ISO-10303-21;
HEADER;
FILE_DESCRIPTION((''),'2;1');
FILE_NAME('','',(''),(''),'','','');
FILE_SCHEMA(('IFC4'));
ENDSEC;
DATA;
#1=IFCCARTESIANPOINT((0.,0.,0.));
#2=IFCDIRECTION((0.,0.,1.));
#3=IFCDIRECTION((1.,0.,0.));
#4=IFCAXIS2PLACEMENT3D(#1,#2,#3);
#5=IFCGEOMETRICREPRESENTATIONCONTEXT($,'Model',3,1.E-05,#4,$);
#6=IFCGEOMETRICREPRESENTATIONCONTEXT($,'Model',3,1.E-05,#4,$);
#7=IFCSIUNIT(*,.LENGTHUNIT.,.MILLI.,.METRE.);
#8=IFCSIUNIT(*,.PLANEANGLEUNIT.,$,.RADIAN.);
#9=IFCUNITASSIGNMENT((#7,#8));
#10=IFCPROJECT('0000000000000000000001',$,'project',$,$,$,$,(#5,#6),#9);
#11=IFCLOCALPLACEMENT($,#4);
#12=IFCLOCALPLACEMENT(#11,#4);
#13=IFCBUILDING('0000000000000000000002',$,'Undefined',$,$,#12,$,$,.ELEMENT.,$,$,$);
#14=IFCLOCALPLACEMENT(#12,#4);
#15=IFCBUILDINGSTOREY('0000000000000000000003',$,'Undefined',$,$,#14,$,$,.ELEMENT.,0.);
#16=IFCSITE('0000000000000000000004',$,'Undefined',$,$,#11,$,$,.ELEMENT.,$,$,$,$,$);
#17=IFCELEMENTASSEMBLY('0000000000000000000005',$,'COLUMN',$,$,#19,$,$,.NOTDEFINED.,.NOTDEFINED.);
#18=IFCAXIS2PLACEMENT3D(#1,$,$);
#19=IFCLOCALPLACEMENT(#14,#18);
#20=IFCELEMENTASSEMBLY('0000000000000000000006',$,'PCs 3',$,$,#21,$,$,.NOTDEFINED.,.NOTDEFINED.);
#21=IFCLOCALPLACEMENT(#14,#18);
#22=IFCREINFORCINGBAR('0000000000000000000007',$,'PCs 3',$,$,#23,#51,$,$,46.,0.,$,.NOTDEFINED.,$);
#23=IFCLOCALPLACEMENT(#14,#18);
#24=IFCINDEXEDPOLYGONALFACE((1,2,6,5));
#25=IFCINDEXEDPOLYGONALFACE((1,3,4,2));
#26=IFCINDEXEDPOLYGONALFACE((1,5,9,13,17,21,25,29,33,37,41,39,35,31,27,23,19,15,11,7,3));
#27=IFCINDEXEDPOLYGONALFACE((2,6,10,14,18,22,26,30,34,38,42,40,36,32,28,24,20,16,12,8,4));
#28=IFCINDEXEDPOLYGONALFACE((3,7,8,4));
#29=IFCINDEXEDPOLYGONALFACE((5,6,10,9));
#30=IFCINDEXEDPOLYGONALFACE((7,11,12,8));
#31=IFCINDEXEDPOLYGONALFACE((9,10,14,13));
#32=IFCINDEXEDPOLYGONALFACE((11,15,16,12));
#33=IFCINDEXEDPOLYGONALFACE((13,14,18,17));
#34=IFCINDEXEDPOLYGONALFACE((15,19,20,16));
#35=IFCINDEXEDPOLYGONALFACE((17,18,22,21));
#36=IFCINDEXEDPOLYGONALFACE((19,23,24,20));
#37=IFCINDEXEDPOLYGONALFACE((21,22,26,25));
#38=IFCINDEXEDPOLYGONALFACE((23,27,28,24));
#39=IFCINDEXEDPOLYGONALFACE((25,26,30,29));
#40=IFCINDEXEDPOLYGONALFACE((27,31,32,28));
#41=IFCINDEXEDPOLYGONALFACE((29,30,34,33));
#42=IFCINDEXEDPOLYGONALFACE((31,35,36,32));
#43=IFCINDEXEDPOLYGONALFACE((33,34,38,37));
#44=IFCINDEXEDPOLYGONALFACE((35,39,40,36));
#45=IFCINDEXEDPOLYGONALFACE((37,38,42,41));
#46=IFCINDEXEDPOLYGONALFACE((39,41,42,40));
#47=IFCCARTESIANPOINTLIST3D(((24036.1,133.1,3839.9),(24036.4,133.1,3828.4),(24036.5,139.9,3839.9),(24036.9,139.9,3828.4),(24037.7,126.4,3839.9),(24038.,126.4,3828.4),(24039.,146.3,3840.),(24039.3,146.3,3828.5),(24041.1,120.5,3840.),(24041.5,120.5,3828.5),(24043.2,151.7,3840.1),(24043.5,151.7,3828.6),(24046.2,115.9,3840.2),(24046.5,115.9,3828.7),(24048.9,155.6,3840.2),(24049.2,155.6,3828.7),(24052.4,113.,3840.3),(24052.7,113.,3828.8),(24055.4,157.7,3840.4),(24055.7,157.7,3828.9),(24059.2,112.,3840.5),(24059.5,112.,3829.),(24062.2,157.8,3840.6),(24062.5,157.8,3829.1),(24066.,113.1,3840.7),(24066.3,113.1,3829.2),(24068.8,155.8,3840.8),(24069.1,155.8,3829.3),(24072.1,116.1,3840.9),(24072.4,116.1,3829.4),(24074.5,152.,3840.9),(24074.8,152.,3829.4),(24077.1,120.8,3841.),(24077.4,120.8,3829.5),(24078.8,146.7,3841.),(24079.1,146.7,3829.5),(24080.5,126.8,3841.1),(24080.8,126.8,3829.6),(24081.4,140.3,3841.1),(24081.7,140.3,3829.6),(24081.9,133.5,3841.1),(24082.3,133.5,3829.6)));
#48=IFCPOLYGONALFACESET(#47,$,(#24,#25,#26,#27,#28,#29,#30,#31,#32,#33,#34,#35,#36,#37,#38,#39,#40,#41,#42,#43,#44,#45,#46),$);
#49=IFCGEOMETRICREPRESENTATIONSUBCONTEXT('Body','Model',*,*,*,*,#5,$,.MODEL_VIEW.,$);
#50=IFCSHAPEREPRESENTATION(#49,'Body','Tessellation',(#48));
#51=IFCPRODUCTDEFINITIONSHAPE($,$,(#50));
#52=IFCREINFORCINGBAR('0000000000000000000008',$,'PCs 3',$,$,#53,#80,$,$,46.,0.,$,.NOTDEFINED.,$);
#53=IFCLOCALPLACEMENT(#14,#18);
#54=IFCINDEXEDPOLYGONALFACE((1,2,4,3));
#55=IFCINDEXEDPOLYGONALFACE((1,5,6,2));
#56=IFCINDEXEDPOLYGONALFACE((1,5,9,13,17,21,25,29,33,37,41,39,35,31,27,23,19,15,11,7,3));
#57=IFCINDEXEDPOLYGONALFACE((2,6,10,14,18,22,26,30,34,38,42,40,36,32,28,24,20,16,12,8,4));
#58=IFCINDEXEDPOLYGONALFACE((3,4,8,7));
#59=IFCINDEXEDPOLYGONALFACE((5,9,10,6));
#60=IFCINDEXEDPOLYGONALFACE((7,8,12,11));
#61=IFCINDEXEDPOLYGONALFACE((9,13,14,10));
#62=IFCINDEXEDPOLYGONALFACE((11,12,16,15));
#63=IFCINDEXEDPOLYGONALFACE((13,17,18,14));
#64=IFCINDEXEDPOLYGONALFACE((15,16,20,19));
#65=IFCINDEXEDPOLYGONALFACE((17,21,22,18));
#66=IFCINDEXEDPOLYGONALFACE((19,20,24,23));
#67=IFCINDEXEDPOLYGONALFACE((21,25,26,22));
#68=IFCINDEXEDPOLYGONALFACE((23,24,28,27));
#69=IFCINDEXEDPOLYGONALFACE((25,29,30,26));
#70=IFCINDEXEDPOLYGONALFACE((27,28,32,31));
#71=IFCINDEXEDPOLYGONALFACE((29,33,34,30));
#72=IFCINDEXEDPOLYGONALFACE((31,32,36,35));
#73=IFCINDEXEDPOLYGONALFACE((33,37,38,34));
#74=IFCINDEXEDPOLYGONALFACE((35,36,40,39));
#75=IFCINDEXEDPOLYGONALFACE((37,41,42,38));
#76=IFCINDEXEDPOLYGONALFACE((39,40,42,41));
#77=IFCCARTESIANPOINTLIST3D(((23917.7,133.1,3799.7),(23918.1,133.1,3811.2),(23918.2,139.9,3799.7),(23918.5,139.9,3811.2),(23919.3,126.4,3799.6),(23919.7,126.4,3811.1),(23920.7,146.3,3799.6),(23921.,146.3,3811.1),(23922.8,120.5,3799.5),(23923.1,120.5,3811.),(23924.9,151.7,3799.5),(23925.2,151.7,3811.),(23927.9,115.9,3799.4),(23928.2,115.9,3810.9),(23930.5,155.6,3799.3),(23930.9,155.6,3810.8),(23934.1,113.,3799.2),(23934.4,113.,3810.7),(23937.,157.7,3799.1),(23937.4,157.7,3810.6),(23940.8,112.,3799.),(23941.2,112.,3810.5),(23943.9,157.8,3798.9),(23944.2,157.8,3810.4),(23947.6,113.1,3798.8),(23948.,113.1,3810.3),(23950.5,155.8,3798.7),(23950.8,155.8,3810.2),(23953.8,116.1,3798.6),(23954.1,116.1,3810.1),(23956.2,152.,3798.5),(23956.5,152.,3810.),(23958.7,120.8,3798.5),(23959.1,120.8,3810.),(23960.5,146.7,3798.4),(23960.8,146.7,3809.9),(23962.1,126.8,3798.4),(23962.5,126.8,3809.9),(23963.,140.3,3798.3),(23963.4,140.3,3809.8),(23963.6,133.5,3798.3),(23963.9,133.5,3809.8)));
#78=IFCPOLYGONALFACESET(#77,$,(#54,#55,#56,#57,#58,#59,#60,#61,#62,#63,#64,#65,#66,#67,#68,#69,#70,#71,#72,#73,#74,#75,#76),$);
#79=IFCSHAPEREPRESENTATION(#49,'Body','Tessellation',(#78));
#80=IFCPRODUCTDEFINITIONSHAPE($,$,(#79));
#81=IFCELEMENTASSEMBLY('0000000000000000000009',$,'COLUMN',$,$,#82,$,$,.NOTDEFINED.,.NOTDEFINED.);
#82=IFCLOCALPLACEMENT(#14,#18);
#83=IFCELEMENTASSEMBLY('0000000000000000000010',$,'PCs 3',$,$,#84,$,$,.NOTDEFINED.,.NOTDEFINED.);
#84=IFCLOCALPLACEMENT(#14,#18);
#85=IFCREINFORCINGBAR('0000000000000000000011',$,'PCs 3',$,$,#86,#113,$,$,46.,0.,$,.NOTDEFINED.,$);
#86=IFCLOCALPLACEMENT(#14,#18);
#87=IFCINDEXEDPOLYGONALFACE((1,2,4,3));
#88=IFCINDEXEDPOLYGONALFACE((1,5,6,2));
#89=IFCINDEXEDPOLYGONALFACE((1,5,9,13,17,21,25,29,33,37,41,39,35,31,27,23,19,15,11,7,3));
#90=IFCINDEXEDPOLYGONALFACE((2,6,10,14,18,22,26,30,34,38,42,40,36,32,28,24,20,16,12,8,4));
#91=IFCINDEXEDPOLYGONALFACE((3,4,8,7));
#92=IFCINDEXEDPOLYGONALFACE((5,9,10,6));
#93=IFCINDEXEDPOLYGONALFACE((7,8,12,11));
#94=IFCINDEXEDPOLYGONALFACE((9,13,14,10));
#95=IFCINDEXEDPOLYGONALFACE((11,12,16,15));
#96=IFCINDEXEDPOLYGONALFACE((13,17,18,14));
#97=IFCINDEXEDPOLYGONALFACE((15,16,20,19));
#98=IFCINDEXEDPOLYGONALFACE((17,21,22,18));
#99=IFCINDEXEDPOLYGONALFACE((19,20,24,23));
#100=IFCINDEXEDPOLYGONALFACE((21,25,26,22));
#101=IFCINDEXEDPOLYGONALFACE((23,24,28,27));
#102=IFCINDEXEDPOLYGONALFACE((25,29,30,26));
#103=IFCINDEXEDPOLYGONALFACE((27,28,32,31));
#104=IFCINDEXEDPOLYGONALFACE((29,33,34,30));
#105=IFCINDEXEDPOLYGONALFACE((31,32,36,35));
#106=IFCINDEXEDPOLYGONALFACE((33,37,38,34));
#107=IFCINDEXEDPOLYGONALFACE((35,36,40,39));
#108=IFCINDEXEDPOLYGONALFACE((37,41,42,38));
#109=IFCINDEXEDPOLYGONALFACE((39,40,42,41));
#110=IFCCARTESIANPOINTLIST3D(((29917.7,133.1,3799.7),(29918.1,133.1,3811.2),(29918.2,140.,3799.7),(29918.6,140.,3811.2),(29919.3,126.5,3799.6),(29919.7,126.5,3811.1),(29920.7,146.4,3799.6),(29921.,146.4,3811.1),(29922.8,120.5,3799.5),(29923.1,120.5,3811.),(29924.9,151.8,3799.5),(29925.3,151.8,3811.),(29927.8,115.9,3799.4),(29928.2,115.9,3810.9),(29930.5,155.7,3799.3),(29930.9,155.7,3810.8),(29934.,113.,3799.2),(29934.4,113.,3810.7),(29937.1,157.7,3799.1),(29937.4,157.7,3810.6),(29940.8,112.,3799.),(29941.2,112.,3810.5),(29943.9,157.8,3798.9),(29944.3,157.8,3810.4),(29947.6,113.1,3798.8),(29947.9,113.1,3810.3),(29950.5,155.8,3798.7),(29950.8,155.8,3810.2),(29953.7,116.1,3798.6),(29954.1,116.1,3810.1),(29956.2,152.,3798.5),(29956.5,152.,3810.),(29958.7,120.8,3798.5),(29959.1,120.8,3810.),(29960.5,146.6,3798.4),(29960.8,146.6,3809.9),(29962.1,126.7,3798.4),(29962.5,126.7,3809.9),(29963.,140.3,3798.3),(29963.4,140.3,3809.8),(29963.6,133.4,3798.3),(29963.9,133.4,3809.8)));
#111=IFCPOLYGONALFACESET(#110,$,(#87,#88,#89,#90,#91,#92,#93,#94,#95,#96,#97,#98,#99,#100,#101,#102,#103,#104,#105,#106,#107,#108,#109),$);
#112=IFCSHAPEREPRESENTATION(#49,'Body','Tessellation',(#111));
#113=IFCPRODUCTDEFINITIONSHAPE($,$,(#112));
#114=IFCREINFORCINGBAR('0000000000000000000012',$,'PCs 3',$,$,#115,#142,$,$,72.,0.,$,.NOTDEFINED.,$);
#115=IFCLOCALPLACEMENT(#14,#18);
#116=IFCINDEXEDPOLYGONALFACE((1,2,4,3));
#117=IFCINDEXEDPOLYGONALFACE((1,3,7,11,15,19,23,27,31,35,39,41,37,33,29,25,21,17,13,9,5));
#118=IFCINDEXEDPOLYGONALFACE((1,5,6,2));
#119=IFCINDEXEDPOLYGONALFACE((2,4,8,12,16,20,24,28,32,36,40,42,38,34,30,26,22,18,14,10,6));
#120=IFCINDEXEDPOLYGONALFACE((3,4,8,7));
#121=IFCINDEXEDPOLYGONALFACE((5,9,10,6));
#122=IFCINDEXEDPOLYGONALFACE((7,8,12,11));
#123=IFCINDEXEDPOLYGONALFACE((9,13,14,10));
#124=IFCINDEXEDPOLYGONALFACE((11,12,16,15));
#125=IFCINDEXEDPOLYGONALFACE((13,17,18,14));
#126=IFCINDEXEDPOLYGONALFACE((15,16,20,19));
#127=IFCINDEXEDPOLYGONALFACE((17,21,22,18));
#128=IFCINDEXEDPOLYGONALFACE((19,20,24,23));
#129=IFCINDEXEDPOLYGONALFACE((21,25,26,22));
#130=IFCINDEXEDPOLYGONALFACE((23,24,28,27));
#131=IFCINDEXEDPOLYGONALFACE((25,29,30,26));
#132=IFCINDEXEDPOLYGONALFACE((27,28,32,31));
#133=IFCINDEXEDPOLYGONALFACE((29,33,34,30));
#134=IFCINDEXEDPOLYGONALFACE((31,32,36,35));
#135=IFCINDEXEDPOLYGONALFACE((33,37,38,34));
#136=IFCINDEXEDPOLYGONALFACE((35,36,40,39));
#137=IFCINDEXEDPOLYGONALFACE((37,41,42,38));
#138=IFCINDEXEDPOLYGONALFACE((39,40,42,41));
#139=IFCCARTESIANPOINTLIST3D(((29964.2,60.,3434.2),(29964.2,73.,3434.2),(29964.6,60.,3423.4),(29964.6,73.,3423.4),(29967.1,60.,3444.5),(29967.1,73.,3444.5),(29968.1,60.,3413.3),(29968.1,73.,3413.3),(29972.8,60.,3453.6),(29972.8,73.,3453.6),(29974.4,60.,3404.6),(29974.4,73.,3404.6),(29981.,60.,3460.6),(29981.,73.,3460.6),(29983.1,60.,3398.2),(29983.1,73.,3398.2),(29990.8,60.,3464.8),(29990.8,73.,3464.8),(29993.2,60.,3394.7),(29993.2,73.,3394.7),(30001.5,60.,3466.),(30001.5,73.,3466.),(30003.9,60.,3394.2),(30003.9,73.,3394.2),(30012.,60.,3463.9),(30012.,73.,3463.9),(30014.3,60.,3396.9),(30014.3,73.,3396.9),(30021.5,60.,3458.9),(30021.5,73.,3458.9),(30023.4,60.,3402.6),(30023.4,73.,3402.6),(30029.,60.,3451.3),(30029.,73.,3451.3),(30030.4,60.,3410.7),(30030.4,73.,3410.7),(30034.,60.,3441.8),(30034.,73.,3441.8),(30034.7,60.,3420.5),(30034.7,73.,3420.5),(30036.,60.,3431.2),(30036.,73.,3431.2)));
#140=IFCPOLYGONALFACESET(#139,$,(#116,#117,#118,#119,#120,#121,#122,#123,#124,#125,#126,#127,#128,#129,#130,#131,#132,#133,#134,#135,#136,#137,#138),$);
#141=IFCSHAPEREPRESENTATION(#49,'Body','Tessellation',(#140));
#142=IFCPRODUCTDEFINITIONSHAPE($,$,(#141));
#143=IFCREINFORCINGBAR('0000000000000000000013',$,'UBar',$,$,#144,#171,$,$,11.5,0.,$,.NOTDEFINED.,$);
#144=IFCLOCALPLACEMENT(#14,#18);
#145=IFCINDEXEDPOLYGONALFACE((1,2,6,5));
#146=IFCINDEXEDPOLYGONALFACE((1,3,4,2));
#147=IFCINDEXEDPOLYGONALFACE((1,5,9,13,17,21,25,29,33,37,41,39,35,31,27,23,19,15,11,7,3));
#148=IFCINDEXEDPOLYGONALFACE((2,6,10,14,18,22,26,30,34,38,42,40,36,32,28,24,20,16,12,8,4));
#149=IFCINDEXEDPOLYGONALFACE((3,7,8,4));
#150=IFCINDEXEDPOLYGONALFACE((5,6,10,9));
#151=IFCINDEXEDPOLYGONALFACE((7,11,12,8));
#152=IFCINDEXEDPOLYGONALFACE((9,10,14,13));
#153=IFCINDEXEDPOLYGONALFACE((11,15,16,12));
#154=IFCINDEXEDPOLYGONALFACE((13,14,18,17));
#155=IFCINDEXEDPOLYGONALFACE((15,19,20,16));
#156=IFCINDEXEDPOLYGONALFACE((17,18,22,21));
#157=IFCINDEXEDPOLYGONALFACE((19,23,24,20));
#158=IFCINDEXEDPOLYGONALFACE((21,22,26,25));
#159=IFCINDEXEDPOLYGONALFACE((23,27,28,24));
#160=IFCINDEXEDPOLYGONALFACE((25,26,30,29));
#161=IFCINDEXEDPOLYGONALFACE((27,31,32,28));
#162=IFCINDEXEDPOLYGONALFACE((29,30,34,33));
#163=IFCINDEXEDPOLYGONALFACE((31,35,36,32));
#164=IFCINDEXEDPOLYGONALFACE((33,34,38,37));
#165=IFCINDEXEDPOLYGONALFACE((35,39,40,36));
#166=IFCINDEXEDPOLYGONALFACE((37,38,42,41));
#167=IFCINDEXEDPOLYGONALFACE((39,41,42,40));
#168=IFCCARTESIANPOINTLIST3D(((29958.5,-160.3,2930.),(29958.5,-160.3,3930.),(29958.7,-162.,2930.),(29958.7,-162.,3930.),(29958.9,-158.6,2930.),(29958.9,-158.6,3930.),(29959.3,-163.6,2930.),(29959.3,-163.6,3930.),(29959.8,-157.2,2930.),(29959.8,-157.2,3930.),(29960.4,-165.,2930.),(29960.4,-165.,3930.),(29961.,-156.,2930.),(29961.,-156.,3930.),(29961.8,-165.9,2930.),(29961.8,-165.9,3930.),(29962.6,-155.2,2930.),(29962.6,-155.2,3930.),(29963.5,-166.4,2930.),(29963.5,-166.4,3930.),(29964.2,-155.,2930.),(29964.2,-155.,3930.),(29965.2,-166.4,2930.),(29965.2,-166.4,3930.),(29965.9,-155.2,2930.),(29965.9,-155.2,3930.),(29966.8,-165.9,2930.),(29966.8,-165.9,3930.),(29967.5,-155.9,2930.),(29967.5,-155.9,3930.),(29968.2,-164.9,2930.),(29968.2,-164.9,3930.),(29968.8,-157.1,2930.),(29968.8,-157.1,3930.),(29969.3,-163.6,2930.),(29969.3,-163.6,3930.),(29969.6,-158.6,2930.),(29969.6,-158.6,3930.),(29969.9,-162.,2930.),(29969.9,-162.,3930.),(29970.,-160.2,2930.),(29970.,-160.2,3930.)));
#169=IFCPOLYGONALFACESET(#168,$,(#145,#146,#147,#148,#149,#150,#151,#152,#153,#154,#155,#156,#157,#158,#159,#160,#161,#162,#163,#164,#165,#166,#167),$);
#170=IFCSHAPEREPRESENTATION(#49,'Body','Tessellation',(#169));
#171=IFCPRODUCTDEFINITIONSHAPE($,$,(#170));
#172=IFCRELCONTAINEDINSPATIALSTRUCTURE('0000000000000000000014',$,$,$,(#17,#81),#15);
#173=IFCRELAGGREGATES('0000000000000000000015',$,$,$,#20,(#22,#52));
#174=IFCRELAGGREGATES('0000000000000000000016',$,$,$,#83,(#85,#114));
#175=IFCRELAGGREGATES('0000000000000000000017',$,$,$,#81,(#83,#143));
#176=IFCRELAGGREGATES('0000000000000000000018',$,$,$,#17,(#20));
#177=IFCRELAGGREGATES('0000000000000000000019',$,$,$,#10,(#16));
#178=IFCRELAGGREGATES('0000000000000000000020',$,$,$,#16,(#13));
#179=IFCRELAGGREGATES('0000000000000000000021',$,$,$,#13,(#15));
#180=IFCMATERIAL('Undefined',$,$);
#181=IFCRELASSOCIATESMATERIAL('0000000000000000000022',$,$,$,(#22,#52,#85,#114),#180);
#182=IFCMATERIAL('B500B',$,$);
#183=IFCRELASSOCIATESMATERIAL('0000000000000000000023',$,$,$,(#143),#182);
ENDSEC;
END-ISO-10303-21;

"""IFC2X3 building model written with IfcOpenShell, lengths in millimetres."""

from ifc_helpers import new_model, entity, si_unit, frame, origin_with_axes, place, context, subcontext, project, spatial, source, transform, mapped, material, element, aggregate, save


model = new_model("IFC2X3")

# Units and contexts
model_context_1 = context("Model", 3, precision=1e-05, world=origin_with_axes())
model_context_2 = context("Model", 3, precision=1e-05, world=origin_with_axes())
body_context = subcontext(model_context_1, "Body", "Model", "MODEL_VIEW")
ifc_project = project(units=[si_unit("LENGTHUNIT", "METRE", prefix="MILLI"), si_unit("PLANEANGLEUNIT", "RADIAN")], contexts=[model_context_1, model_context_2])

# Site, building, storey
site_placement = place(None, origin_with_axes())
site = spatial("IfcSite", under=ifc_project, at=site_placement, Name="Undefined", CompositionType="ELEMENT")
building_placement = place(site_placement, origin_with_axes())
building = spatial("IfcBuilding", under=site, at=building_placement, Name="Undefined", CompositionType="ELEMENT")
storey_placement = place(building_placement, origin_with_axes())
storey = spatial("IfcBuildingStorey", under=building, at=storey_placement, Name="Undefined", CompositionType="ELEMENT", Elevation=0.0)

# Element assemblies
assembly_1_placement = place(storey_placement, origin_with_axes())
assembly_1 = element("IfcElementAssembly", 1, at=assembly_1_placement, inside=storey, Name="COLUMN", AssemblyPlace="NOTDEFINED", PredefinedType="NOTDEFINED")
assembly_2_placement = place(assembly_1_placement, origin_with_axes())
assembly_2 = element("IfcElementAssembly", 2, at=assembly_2_placement, Name="PCs 3", AssemblyPlace="NOTDEFINED", PredefinedType="NOTDEFINED")

# Shared definitions
ifc_material_1 = material(Name="Undefined")

# Reinforcing bars
shared_shape_1 = source(origin_with_axes(), body_context, "Body", "AdvancedSweptSolid", [
    entity("IfcSweptDiskSolid", entity("IfcTrimmedCurve", entity("IfcLine", entity("IfcCartesianPoint", [0.0, 0.0, 0.0]), entity("IfcVector", entity("IfcDirection", [1.0, 0.0, 0.0]), 1.0)), [entity("IfcParameterValue", 0.0)], [entity("IfcParameterValue", 11.5)], True, "PARAMETER"), 23.0, None, 0.0, 11.5),
])
reinforcing_bar_1_placement = place(assembly_2_placement, frame((24059.3, 135.0, 3829.0), z_axis=(0.008302, -0.999966, 0.000225), x_axis=(-0.02711, 0.0, 0.999632)))
reinforcing_bar_1 = element("IfcReinforcingBar", 3, at=reinforcing_bar_1_placement, material=ifc_material_1, Name="PCs 3", BarRole="NOTDEFINED", CrossSectionArea=0.0, NominalDiameter=46.0, context=body_context, shape_type="MappedRepresentation", body=[
    mapped(shared_shape_1, transform((0.0, 0.0, 0.0))),
])
shared_shape_2 = source(origin_with_axes(), body_context, "Body", "AdvancedSweptSolid", [
    entity("IfcSweptDiskSolid", entity("IfcTrimmedCurve", entity("IfcLine", entity("IfcCartesianPoint", [0.0, 0.0, 0.0]), entity("IfcVector", entity("IfcDirection", [1.0, 0.0, 0.0]), 1.0)), [entity("IfcParameterValue", 0.0)], [entity("IfcParameterValue", 11.5)], True, "PARAMETER"), 23.0, None, 0.0, 11.5),
])
reinforcing_bar_2_placement = place(assembly_2_placement, frame((23940.7, 135.0, 3799.0), z_axis=(0.008367, -0.999965, -0.000251), x_axis=(0.029977, 0.0, 0.999551)))
reinforcing_bar_2 = element("IfcReinforcingBar", 4, at=reinforcing_bar_2_placement, material=ifc_material_1, Name="PCs 3", BarRole="NOTDEFINED", CrossSectionArea=0.0, NominalDiameter=46.0, context=body_context, shape_type="MappedRepresentation", body=[
    mapped(shared_shape_2, transform((0.0, 0.0, 0.0))),
])
aggregate(assembly_2, [reinforcing_bar_1, reinforcing_bar_2])

# Element assemblies, reinforcing bars
assembly_3_placement = place(storey_placement, origin_with_axes())
assembly_3 = element("IfcElementAssembly", 5, at=assembly_3_placement, inside=storey, Name="COLUMN", AssemblyPlace="NOTDEFINED", PredefinedType="NOTDEFINED")
assembly_4_placement = place(assembly_3_placement, origin_with_axes())
assembly_4 = element("IfcElementAssembly", 6, at=assembly_4_placement, Name="PCs 3", AssemblyPlace="NOTDEFINED", PredefinedType="NOTDEFINED")
shared_shape_3 = source(origin_with_axes(), body_context, "Body", "AdvancedSweptSolid", [
    entity("IfcSweptDiskSolid", entity("IfcTrimmedCurve", entity("IfcLine", entity("IfcCartesianPoint", [0.0, 0.0, 0.0]), entity("IfcVector", entity("IfcDirection", [1.0, 0.0, 0.0]), 1.0)), [entity("IfcParameterValue", 0.0)], [entity("IfcParameterValue", 11.5)], True, "PARAMETER"), 23.0, None, 0.0, 11.5),
])
reinforcing_bar_3_placement = place(assembly_4_placement, frame((29940.7, 135.0, 3799.0), z_axis=(0.006688, -0.999978, -0.000201), x_axis=(0.029977, 0.0, 0.999551)))
reinforcing_bar_3 = element("IfcReinforcingBar", 7, at=reinforcing_bar_3_placement, material=ifc_material_1, Name="PCs 3", BarRole="NOTDEFINED", CrossSectionArea=0.0, NominalDiameter=46.0, context=body_context, shape_type="MappedRepresentation", body=[
    mapped(shared_shape_3, transform((0.0, 0.0, 0.0))),
])
shared_shape_4 = source(origin_with_axes(), body_context, "Body", "AdvancedSweptSolid", [
    entity("IfcSweptDiskSolid", entity("IfcTrimmedCurve", entity("IfcLine", entity("IfcCartesianPoint", [0.0, 0.0, 0.0]), entity("IfcVector", entity("IfcDirection", [1.0, 0.0, 0.0]), 1.0)), [entity("IfcParameterValue", 0.0)], [entity("IfcParameterValue", 13.0)], True, "PARAMETER"), 36.0, None, 0.0, 13.0),
])
reinforcing_bar_4_placement = place(assembly_4_placement, frame((30000.0, 73.0, 3430.0), z_axis=(0.108031, 0.0, -0.994148), x_axis=(0.0, -1.0, 0.0)))
reinforcing_bar_4 = element("IfcReinforcingBar", 8, at=reinforcing_bar_4_placement, material=ifc_material_1, Name="PCs 3", BarRole="NOTDEFINED", CrossSectionArea=0.0, NominalDiameter=72.0, context=body_context, shape_type="MappedRepresentation", body=[
    mapped(shared_shape_4, transform((0.0, 0.0, 0.0))),
])
aggregate(assembly_4, [reinforcing_bar_3, reinforcing_bar_4])

# Reinforcing bar
ifc_material_2 = material(Name="B500B")
shared_shape_5 = source(origin_with_axes(), body_context, "Body", "AdvancedSweptSolid", [
    entity("IfcSweptDiskSolid", entity("IfcTrimmedCurve", entity("IfcLine", entity("IfcCartesianPoint", [0.0, 0.0, 0.0]), entity("IfcVector", entity("IfcDirection", [1.0, 0.0, 0.0]), 1.0)), [entity("IfcParameterValue", 0.0)], [entity("IfcParameterValue", 1000.0)], True, "PARAMETER"), 5.8, None, 0.0, 1000.0),
])
reinforcing_bar_5_placement = place(assembly_3_placement, frame((29964.3, -160.7, 3930.0), z_axis=(-0.006667, 0.999978, 0.0), x_axis=(0.0, 0.0, -1.0)))
reinforcing_bar_5 = element("IfcReinforcingBar", 9, at=reinforcing_bar_5_placement, material=ifc_material_2, Name="UBar", BarRole="NOTDEFINED", CrossSectionArea=0.0, NominalDiameter=11.5, context=body_context, shape_type="MappedRepresentation", body=[
    mapped(shared_shape_5, transform((0.0, 0.0, 0.0))),
])
aggregate(assembly_3, [assembly_4, reinforcing_bar_5])
aggregate(assembly_1, [assembly_2])

save(model, "model.ifc")
